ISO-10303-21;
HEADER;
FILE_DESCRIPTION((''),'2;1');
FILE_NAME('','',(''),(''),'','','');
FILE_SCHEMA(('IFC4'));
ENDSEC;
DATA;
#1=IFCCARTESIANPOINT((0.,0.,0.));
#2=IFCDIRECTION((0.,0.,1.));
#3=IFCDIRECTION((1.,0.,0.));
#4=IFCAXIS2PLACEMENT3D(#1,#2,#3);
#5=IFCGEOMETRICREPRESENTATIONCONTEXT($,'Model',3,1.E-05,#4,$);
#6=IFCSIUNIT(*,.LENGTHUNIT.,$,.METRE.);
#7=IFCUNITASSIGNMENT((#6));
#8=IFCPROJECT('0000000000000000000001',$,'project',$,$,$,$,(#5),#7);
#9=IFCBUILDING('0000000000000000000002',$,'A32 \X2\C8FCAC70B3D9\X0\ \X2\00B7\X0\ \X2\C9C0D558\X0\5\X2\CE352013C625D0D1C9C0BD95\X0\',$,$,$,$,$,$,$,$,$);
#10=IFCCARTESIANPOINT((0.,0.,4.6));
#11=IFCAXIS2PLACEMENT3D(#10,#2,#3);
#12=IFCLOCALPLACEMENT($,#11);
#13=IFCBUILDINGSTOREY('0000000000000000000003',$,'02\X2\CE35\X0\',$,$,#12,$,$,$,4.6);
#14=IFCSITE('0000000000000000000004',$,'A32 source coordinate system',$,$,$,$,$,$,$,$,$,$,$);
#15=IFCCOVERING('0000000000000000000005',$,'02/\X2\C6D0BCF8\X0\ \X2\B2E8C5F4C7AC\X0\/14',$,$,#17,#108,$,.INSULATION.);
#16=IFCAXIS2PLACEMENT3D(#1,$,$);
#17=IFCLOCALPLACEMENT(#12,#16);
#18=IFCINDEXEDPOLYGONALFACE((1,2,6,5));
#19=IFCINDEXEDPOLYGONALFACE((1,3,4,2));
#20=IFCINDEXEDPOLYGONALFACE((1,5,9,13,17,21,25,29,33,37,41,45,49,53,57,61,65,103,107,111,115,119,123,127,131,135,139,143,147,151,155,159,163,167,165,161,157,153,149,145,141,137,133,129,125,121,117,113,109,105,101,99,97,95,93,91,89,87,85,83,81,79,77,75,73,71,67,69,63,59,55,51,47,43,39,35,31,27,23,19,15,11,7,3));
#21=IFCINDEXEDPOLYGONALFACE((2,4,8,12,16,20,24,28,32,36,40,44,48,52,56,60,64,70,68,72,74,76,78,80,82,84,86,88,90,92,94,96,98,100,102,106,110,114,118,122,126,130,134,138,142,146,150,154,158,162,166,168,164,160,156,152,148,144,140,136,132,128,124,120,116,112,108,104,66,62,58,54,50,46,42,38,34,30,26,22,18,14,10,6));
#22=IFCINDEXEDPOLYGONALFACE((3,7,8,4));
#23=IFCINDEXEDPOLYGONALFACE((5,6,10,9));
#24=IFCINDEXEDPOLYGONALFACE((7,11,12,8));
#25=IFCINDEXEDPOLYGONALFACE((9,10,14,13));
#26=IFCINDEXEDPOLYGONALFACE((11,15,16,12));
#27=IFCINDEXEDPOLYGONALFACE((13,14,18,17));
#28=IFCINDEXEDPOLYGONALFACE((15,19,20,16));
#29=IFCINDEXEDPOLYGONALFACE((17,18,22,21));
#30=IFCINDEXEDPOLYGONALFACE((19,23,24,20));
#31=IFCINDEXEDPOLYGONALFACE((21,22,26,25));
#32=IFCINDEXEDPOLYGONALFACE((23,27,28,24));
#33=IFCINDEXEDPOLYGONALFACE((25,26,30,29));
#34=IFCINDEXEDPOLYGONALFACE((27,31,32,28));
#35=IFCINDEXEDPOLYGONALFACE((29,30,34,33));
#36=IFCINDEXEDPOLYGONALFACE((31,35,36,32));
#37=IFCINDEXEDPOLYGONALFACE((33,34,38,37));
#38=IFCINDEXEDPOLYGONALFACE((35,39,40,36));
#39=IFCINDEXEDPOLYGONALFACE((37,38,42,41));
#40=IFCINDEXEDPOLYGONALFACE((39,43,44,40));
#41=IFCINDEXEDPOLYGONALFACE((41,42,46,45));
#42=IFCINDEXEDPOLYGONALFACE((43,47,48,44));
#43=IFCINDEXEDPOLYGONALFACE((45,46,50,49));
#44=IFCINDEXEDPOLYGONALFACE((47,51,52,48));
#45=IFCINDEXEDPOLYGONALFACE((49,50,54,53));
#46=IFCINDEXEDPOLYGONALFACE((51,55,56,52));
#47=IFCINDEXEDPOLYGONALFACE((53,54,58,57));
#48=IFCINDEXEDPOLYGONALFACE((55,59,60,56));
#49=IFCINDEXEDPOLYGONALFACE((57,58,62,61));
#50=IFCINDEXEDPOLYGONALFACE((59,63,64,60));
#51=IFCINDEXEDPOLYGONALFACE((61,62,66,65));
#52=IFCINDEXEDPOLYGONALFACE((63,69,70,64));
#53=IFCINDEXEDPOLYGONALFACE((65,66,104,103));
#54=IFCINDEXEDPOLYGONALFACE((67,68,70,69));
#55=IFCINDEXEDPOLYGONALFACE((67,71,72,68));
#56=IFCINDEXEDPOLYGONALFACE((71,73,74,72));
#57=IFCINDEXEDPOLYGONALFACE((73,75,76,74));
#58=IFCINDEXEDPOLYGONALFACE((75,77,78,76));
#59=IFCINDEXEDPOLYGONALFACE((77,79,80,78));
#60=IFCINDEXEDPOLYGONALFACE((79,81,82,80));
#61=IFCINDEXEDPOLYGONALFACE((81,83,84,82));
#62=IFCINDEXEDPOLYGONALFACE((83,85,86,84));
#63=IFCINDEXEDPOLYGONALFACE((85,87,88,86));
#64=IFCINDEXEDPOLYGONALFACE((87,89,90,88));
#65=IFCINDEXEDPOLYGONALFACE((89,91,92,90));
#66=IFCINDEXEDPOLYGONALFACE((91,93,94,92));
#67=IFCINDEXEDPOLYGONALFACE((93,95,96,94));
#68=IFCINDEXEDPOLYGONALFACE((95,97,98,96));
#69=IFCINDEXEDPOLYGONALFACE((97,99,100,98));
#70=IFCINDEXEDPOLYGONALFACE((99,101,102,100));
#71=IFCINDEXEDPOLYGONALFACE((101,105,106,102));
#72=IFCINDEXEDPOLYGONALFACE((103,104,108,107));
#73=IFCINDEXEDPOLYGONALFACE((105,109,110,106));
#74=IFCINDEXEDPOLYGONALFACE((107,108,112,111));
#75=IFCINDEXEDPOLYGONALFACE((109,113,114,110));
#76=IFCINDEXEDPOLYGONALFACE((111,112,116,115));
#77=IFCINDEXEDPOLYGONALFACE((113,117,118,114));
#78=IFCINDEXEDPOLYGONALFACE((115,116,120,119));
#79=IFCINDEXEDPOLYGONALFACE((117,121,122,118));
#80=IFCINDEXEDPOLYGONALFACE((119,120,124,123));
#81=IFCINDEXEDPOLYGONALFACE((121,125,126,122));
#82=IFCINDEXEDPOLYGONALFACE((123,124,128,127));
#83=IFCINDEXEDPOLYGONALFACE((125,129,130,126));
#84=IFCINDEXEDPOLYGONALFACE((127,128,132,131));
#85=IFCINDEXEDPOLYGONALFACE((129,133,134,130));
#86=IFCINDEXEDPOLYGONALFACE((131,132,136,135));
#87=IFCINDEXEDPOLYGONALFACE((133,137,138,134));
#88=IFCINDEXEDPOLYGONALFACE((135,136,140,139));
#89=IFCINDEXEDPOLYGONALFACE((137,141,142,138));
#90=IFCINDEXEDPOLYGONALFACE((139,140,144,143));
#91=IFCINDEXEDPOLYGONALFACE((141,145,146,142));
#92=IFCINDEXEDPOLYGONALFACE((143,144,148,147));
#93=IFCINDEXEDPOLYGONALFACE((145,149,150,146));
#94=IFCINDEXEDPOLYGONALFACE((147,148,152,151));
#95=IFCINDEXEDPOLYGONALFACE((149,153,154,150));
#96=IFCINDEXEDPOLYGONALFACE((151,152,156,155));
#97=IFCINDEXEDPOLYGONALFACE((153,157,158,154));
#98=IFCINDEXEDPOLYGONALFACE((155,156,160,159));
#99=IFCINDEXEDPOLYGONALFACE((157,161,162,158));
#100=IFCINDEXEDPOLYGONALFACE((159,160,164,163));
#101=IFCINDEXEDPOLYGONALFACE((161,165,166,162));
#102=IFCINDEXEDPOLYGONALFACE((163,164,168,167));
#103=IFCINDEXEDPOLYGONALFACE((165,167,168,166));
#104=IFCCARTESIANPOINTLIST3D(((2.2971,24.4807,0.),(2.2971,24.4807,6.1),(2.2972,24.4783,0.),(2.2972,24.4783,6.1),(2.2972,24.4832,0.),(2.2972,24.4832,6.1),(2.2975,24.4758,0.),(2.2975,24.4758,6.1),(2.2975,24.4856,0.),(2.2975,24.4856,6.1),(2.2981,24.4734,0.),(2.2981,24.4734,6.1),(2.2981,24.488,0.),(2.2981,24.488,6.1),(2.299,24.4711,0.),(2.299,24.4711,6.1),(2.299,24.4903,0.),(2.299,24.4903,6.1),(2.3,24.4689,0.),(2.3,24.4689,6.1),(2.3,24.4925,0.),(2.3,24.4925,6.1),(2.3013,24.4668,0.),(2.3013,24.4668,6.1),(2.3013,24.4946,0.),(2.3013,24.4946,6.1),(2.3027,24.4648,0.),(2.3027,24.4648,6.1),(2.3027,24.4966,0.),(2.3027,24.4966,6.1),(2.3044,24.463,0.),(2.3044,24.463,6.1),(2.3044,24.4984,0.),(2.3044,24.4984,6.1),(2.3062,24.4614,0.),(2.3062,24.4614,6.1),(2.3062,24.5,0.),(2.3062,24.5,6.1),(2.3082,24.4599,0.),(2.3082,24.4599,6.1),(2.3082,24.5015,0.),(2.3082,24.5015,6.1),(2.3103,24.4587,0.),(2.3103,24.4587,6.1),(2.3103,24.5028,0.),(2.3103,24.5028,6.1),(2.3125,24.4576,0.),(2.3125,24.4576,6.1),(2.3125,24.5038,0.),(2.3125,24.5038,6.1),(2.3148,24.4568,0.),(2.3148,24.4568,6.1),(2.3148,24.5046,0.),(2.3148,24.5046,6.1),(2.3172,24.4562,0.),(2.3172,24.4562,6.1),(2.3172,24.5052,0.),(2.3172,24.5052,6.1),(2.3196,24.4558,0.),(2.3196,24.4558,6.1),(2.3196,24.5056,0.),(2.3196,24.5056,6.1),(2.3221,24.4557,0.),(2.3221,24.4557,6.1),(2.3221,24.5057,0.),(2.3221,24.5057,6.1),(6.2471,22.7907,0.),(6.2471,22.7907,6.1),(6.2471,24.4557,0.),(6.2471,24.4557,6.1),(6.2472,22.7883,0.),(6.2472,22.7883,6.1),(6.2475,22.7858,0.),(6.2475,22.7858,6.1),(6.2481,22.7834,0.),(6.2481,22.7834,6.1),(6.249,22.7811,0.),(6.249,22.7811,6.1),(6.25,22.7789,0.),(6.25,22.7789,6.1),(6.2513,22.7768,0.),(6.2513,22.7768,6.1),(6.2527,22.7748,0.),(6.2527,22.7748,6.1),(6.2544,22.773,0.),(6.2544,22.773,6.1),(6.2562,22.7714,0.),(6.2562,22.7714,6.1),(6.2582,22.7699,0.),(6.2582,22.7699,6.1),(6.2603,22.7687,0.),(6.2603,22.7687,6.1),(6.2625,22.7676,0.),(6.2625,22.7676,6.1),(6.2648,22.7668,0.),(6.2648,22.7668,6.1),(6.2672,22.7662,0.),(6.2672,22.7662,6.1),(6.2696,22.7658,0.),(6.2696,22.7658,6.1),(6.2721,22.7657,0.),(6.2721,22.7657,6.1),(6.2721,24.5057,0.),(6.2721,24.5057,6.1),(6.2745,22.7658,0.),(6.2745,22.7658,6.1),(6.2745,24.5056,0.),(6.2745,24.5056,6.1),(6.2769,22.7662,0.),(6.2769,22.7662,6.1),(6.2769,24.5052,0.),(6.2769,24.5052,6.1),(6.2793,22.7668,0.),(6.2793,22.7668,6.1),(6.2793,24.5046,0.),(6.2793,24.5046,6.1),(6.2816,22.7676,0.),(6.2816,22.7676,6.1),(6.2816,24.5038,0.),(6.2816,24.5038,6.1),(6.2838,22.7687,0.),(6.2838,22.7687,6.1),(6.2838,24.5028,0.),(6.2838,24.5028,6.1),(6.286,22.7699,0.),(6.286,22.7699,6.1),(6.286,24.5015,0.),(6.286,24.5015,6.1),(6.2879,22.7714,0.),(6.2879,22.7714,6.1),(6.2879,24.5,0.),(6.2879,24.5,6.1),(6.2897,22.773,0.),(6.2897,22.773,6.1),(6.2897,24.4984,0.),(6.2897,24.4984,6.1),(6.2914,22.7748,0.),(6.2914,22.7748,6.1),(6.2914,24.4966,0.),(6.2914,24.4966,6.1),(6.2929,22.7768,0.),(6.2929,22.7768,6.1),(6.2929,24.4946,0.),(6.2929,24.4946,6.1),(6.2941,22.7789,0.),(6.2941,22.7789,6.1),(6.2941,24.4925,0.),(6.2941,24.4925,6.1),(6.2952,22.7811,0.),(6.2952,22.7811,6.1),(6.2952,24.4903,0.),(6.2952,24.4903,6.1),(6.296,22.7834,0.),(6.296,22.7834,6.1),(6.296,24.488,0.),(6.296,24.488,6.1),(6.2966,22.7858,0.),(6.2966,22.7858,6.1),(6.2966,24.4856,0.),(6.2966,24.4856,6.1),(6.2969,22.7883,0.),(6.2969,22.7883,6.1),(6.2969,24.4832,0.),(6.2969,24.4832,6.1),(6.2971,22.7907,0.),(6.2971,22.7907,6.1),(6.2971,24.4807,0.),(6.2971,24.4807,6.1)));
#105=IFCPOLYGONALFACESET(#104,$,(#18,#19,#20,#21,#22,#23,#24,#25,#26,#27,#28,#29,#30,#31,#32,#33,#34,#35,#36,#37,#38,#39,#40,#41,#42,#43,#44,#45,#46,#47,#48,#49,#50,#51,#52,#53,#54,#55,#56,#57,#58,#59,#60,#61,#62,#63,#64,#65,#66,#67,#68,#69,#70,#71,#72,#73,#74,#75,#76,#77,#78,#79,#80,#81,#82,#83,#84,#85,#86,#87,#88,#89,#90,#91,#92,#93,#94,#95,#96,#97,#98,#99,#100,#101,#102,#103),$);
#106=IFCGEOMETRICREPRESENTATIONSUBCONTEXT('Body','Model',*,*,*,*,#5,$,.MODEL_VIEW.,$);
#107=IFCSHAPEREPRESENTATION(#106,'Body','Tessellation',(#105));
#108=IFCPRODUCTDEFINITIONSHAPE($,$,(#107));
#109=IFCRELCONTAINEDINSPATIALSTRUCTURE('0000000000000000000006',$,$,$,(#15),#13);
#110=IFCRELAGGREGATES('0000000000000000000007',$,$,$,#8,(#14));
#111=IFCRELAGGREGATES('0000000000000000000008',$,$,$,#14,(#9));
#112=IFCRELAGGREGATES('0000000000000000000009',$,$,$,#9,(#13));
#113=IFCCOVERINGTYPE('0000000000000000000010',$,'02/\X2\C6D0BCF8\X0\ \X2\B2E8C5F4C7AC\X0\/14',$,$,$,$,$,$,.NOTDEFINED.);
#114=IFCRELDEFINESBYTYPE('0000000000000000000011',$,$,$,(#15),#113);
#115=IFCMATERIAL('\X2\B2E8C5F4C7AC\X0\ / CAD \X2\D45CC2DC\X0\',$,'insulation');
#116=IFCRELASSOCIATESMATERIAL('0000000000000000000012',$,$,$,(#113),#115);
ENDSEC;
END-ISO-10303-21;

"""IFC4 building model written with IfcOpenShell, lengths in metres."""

from ifc_helpers import new_model, si_unit, frame, origin, origin_with_axes, place, context, subcontext, project, spatial, polyline, outline, extrude, source, transform, mapped, material, type_object, type_shapes, element, save


model = new_model("IFC4")

# Units and contexts
model_context = context("Model", 3, precision=1e-05, world=origin_with_axes())
body_context = subcontext(model_context, "Body", "Model", "MODEL_VIEW")
ifc_project = project(units=[si_unit("LENGTHUNIT", "METRE")], contexts=[model_context])

# Site, building, storey
site = spatial("IfcSite", under=ifc_project, Name="A32 source coordinate system")
building = spatial("IfcBuilding", under=site, Name="A32 주거동 · 지하5층–옥탑지붕")
storey_placement = place(None, frame((0.0, 0.0, 4.6), z_axis=(0.0, 0.0, 1.0), x_axis=(1.0, 0.0, 0.0)))
storey = spatial("IfcBuildingStorey", under=building, at=storey_placement, Name="02층", Elevation=4.6)

# Covering
ifc_material = material(Name="단열재 / CAD 표시", Category="insulation")
covering_type_1 = type_object("IfcCoveringType", Name="02/원본 단열재/14", PredefinedType="NOTDEFINED", material=ifc_material)
shared_shape_1 = source(origin(), body_context, "Body", "SweptSolid", [
    extrude(outline(polyline([(2.3103, 24.4587), (2.3082, 24.4599), (2.3062, 24.4614), (2.3044, 24.463), (2.3027, 24.4648), (2.3013, 24.4668), (2.3, 24.4689), (2.299, 24.4711), (2.2981, 24.4734), (2.2975, 24.4758), (2.2972, 24.4783), (2.2971, 24.4807), (2.2972, 24.4832), (2.2975, 24.4856), (2.2981, 24.488), (2.299, 24.4903), (2.3, 24.4925), (2.3013, 24.4946), (2.3027, 24.4966), (2.3044, 24.4984), (2.3062, 24.5), (2.3082, 24.5015), (2.3103, 24.5028), (2.3125, 24.5038), (2.3148, 24.5046), (2.3172, 24.5052), (2.3196, 24.5056), (2.3221, 24.5057), (6.2721, 24.5057), (6.2745, 24.5056), (6.2769, 24.5052), (6.2793, 24.5046), (6.2816, 24.5038), (6.2838, 24.5028), (6.286, 24.5015), (6.2879, 24.5), (6.2897, 24.4984), (6.2914, 24.4966), (6.2929, 24.4946), (6.2941, 24.4925), (6.2952, 24.4903), (6.296, 24.488), (6.2966, 24.4856), (6.2969, 24.4832), (6.2971, 24.4807), (6.2971, 22.7907), (6.2969, 22.7883), (6.2966, 22.7858), (6.296, 22.7834), (6.2952, 22.7811), (6.2941, 22.7789), (6.2929, 22.7768), (6.2914, 22.7748), (6.2897, 22.773), (6.2879, 22.7714), (6.286, 22.7699), (6.2838, 22.7687), (6.2816, 22.7676), (6.2793, 22.7668), (6.2769, 22.7662), (6.2745, 22.7658), (6.2721, 22.7657), (6.2696, 22.7658), (6.2672, 22.7662), (6.2648, 22.7668), (6.2625, 22.7676), (6.2603, 22.7687), (6.2582, 22.7699), (6.2562, 22.7714), (6.2544, 22.773), (6.2527, 22.7748), (6.2513, 22.7768), (6.25, 22.7789), (6.249, 22.7811), (6.2481, 22.7834), (6.2475, 22.7858), (6.2472, 22.7883), (6.2471, 22.7907), (6.2471, 24.4557), (2.3221, 24.4557), (2.3196, 24.4558), (2.3172, 24.4562), (2.3148, 24.4568), (2.3125, 24.4576), (2.3103, 24.4587)])), origin(), (0.0, 0.0, 1.0), 6.1),
])
type_shapes(covering_type_1, [shared_shape_1])
covering_1_placement = place(storey_placement, origin_with_axes())
element("IfcCovering", 1, at=covering_1_placement, inside=storey, type_object=covering_type_1, Name="02/원본 단열재/14", PredefinedType="INSULATION", context=body_context, shape_type="MappedRepresentation", body=[
    mapped(shared_shape_1, transform((0.0, 0.0, 0.0), scale=1.0)),
])

save(model, "model.ifc")
